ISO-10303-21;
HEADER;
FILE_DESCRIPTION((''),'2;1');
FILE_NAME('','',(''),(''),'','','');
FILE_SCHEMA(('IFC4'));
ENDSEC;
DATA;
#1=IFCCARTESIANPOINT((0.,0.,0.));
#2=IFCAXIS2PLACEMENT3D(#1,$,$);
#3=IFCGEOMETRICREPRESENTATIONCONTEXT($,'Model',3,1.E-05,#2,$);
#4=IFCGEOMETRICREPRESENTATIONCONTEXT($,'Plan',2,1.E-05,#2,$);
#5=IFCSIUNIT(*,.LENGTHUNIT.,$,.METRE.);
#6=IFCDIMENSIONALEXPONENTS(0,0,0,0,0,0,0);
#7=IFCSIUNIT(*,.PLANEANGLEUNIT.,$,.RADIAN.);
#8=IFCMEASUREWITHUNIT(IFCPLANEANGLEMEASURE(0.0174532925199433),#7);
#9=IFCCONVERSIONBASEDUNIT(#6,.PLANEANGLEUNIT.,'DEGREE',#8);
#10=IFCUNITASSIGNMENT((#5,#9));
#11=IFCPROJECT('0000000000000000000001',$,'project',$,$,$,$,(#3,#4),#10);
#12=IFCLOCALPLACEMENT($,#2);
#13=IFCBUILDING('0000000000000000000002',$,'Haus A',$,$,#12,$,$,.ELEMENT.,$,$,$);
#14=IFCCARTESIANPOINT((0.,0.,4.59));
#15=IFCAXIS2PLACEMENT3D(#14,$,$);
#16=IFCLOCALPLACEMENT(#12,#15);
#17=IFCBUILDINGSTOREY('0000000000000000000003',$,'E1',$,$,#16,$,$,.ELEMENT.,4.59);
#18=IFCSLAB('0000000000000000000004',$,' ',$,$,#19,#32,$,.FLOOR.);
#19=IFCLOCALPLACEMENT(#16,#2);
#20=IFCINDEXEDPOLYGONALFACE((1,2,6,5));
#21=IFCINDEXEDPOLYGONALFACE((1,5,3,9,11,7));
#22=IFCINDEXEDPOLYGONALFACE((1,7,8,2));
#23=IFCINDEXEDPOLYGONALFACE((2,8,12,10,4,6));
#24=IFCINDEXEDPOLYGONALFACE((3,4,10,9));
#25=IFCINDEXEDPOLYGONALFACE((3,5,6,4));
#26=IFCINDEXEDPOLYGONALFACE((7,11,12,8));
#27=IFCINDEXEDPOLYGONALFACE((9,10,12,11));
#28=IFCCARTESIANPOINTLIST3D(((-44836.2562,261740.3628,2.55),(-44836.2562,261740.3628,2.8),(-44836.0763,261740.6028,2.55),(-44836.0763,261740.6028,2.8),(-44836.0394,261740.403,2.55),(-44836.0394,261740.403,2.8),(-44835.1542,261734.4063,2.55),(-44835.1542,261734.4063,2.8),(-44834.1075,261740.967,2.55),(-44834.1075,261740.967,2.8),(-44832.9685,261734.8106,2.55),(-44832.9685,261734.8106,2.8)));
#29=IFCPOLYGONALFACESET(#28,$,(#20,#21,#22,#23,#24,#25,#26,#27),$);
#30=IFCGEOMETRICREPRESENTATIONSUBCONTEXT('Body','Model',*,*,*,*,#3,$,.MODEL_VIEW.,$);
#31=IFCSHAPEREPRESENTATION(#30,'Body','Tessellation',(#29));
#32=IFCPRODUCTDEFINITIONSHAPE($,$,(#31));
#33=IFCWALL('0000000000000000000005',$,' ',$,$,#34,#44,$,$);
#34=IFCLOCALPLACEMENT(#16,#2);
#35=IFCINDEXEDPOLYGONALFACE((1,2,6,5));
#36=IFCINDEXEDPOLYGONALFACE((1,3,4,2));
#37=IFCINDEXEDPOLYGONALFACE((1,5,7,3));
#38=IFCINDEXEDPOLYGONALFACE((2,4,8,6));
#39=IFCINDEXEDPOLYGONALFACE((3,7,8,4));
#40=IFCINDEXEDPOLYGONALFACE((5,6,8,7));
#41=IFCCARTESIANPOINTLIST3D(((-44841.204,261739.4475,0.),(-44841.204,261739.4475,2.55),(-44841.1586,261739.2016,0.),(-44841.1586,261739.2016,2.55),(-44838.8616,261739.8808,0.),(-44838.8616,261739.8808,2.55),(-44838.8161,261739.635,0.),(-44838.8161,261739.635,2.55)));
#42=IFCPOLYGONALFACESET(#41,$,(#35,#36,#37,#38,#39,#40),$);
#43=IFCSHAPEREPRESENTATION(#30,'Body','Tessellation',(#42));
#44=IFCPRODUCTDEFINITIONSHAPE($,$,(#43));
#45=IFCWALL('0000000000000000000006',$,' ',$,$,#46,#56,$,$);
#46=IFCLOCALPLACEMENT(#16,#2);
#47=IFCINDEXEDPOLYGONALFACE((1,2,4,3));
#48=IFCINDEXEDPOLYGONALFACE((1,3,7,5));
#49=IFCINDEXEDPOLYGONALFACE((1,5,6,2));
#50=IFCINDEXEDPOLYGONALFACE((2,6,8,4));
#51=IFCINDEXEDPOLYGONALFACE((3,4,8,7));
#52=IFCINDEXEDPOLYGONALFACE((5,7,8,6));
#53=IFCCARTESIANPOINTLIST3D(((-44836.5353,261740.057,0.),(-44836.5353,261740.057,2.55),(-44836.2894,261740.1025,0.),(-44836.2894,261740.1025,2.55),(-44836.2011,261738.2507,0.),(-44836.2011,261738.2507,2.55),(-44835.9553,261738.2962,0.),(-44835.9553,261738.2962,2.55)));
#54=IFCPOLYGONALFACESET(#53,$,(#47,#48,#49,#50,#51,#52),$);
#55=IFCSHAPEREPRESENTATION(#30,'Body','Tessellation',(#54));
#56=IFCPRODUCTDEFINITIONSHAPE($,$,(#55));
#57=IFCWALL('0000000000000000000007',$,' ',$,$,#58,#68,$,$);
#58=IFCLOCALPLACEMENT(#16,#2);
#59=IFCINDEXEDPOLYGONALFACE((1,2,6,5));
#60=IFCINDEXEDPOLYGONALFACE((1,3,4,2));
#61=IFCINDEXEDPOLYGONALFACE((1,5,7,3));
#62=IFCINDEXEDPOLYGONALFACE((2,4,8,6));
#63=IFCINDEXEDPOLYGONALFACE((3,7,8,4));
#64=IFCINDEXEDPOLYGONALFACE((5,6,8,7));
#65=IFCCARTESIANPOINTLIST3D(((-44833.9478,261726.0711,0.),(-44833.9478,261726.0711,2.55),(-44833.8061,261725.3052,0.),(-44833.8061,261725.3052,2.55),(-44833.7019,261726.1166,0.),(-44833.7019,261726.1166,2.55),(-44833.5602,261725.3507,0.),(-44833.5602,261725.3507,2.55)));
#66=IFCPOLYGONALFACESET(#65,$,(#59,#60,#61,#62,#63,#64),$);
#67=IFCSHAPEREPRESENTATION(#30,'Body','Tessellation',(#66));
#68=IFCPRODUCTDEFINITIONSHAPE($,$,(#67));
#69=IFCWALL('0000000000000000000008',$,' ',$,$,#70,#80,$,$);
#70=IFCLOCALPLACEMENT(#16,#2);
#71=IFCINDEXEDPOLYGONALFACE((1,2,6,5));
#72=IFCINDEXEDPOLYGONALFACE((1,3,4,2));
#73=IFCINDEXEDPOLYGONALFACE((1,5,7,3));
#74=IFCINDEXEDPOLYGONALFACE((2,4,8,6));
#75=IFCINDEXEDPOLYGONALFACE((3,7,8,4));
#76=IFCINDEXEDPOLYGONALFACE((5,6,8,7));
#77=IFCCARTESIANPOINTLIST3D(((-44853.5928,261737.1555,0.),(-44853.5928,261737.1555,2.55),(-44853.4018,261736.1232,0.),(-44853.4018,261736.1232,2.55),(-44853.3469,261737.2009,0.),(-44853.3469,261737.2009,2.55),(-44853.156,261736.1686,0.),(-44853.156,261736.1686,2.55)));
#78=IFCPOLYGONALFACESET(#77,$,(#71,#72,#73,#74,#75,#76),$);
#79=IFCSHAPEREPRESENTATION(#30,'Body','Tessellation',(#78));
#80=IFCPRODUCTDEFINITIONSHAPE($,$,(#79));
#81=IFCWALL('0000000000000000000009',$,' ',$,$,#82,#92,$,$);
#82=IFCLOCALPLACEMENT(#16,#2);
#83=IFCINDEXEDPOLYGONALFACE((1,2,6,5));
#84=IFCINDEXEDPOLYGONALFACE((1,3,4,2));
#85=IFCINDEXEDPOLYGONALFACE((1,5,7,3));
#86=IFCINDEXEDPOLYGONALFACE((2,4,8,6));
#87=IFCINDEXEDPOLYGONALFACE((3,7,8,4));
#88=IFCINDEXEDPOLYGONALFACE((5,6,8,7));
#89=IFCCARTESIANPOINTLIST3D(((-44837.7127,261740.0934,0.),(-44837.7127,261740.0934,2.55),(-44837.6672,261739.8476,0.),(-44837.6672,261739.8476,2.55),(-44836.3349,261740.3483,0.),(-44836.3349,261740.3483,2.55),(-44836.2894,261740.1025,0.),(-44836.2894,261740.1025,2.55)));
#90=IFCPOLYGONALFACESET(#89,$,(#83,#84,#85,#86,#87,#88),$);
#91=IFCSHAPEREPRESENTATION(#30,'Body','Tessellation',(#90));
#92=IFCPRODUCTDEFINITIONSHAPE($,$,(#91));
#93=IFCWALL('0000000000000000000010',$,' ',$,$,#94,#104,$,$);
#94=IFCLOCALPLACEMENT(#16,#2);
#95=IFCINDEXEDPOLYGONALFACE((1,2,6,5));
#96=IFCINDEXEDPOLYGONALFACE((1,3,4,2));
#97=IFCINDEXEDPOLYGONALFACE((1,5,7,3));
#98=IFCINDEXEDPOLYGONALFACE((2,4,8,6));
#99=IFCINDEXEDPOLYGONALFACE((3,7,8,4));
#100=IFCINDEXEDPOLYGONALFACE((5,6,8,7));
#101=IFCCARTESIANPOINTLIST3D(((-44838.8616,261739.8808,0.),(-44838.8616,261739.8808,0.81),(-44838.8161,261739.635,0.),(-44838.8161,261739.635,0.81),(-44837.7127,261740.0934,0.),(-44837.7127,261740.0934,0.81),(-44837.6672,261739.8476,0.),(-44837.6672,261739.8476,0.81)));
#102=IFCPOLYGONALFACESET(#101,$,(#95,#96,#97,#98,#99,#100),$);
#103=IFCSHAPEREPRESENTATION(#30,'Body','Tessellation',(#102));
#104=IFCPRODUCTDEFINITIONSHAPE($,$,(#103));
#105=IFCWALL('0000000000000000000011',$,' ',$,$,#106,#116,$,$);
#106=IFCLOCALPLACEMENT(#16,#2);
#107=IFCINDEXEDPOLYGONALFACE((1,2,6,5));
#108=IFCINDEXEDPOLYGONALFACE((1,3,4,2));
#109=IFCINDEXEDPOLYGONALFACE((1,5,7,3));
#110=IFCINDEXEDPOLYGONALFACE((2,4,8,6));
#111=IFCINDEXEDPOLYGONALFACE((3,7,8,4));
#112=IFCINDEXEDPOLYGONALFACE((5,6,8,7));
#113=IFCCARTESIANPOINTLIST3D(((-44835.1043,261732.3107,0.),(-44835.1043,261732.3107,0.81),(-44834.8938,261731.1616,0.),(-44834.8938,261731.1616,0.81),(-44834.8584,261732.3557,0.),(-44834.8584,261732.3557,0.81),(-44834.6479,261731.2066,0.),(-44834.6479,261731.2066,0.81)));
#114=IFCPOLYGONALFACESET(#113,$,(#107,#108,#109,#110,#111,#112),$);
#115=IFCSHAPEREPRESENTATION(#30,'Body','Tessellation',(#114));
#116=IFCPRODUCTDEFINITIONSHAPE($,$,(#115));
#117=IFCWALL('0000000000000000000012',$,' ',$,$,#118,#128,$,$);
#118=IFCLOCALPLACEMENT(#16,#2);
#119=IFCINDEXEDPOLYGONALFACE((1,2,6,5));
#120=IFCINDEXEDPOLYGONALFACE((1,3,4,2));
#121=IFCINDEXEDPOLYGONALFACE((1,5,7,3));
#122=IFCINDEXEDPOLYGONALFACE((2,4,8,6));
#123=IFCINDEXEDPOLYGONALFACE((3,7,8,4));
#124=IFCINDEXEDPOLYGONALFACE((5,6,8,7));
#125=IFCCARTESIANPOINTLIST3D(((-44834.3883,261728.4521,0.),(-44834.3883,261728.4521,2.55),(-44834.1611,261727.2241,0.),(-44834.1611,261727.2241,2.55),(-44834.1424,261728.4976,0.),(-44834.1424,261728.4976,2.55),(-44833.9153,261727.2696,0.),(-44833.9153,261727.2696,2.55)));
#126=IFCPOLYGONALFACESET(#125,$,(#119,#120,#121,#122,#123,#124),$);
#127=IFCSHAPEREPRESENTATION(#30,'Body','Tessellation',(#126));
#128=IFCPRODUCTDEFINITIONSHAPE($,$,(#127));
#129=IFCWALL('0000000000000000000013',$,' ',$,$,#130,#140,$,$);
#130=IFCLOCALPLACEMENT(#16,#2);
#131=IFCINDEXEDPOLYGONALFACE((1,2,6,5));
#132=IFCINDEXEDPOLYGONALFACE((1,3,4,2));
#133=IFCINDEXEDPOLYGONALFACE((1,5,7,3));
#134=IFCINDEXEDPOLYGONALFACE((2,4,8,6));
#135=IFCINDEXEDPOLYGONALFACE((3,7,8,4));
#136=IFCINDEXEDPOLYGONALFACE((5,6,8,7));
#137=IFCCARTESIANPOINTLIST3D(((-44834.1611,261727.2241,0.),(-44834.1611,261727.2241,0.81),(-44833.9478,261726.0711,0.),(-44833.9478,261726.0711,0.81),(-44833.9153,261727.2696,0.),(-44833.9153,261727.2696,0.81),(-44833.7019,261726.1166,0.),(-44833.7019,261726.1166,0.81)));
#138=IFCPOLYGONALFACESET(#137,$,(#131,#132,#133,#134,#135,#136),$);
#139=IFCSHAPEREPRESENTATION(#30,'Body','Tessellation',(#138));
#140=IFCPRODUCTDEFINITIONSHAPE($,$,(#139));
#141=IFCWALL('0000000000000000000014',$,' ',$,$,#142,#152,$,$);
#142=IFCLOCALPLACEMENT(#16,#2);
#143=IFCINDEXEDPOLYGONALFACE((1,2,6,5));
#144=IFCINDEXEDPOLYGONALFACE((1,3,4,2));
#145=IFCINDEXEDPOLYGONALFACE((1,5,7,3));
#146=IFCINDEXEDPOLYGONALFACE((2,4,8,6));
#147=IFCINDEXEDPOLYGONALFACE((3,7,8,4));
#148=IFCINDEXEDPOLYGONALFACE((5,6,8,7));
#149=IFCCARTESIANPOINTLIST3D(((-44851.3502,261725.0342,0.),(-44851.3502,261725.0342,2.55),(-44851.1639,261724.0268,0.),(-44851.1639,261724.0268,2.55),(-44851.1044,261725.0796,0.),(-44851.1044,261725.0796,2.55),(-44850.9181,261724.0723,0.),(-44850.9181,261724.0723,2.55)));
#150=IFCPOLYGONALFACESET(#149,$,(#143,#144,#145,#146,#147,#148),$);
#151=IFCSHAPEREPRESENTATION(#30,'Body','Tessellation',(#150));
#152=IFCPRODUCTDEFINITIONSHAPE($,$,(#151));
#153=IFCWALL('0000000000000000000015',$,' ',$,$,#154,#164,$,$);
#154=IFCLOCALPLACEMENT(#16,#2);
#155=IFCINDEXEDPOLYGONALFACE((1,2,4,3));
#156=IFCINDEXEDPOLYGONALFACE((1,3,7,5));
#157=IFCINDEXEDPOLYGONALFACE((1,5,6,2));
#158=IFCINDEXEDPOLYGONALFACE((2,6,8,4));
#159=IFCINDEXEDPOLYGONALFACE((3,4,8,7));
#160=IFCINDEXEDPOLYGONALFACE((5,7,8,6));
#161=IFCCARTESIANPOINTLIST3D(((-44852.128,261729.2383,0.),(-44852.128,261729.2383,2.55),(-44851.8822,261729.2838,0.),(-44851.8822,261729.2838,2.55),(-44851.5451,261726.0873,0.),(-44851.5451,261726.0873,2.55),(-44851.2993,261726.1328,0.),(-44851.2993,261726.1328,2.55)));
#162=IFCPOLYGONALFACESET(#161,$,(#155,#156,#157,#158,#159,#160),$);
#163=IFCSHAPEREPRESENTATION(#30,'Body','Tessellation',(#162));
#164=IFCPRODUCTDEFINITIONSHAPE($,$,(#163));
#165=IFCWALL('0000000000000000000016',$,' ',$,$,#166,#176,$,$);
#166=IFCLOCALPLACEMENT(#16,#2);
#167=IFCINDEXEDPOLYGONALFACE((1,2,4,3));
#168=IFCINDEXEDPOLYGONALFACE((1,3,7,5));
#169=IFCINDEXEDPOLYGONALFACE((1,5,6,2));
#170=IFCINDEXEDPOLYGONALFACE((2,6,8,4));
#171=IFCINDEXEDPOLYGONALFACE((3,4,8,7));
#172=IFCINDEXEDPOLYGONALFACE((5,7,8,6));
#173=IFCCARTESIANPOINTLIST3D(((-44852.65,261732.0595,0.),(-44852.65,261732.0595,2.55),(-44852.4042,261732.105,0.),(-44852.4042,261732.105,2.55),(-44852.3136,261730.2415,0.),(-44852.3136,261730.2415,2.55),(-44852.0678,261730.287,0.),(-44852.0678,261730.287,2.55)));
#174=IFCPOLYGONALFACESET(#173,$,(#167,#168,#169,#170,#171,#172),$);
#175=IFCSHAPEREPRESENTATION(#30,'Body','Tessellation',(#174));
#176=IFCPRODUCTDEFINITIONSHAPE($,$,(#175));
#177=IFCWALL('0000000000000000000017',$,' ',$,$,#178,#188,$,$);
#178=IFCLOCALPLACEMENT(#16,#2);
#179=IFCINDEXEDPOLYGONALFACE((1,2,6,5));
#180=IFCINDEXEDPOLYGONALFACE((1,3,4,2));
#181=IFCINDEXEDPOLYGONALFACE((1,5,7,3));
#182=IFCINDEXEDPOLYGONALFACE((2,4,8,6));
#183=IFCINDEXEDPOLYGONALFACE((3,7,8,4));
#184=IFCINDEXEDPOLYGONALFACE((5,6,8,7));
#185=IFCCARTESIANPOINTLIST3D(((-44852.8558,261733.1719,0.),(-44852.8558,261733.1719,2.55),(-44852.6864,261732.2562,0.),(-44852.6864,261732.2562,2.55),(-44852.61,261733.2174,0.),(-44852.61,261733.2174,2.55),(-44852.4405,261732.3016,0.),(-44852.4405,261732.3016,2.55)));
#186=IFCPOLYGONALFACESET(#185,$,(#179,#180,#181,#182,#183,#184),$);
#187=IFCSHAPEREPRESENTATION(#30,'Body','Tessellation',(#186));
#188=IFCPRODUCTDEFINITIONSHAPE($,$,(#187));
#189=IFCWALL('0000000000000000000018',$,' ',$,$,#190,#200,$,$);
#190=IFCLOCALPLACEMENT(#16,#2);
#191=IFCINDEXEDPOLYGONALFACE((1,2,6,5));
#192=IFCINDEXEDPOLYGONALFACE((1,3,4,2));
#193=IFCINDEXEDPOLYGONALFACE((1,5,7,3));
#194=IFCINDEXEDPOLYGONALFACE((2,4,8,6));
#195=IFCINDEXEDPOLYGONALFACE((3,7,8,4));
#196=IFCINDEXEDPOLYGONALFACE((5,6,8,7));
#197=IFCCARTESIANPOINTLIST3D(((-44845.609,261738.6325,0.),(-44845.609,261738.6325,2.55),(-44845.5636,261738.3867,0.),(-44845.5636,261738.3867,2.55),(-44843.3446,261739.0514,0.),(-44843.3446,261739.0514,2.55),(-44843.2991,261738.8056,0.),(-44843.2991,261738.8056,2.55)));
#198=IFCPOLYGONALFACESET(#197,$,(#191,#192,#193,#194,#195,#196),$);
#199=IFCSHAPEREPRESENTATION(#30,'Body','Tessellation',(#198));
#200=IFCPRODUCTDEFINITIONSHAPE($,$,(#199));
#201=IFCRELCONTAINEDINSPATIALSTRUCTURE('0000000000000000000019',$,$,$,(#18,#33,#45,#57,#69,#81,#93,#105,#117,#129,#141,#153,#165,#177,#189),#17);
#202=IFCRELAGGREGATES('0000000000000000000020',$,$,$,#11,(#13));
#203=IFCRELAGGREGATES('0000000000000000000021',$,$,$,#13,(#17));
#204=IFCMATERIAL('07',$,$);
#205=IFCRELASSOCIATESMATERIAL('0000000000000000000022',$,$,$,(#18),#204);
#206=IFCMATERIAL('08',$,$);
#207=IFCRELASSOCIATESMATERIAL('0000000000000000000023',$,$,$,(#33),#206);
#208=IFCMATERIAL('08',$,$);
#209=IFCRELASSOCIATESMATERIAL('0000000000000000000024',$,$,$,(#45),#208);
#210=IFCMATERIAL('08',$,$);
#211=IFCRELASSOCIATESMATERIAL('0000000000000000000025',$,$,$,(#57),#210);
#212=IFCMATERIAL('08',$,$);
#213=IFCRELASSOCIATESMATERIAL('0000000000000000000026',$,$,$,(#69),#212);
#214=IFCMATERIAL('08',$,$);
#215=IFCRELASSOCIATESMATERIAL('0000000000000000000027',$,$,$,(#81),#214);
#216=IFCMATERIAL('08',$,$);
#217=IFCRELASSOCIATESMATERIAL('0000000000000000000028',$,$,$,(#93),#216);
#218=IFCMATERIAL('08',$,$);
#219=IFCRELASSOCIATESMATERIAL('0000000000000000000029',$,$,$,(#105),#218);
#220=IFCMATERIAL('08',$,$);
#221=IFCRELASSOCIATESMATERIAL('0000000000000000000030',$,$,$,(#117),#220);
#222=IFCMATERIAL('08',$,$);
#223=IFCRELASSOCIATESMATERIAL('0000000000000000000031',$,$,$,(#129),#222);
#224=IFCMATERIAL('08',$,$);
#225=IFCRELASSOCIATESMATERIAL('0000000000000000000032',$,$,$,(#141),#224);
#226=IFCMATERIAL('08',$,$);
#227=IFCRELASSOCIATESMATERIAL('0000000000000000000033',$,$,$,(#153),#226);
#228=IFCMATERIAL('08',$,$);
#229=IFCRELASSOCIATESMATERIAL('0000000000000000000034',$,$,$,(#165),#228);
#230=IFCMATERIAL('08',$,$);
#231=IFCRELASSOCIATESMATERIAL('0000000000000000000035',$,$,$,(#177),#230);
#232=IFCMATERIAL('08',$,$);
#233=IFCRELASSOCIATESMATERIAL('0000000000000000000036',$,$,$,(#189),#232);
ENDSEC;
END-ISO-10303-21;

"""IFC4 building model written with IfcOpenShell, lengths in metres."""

from ifc_helpers import new_model, entity, si_unit, converted_unit, frame, frame_2d, origin, origin_with_axes, place, context, subcontext, project, spatial, polyline, rectangle, outline, extrude, material, element, save


model = new_model("IFC4")

# Units and contexts
model_context = context("Model", 3, precision=1e-05, world=origin())
plan_context = context("Plan", 2, precision=1e-05, world=origin())
body_context = subcontext(model_context, "Body", "Model", "MODEL_VIEW")
ifc_project = project(units=[si_unit("LENGTHUNIT", "METRE"), converted_unit("PLANEANGLEUNIT", "DEGREE", entity("IfcPlaneAngleMeasure", 0.0174532925199433), si_unit("PLANEANGLEUNIT", "RADIAN"), dimensions=[0, 0, 0, 0, 0, 0, 0])], contexts=[model_context, plan_context])

# Building, storey
building_placement = place(None, origin())
building = spatial("IfcBuilding", under=ifc_project, at=building_placement, Name="Haus A", CompositionType="ELEMENT")
storey_placement = place(building_placement, frame((0.0, 0.0, 4.59)))
storey = spatial("IfcBuildingStorey", under=building, at=storey_placement, Name="E1", CompositionType="ELEMENT", Elevation=4.59)

# Slab
ifc_material_1 = material(Name="07")
slab_placement = place(storey_placement, frame((-44836.2562, 261734.4063, 2.55)))
element("IfcSlab", 1, at=slab_placement, inside=storey, material=ifc_material_1, Name=" ", PredefinedType="FLOOR", context=body_context, shape_type="SweptSolid", body=[
    extrude(outline(polyline([(1.102, 0.0), (3.2878, 0.4044), (2.1488, 6.5608), (0.1799, 6.1965), (0.2169, 5.9967), (0.0, 5.9566), (1.102, 0.0)])), origin_with_axes(), (0.0, 0.0, 1.0), 0.25),
])

# Walls
ifc_material_2 = material(Name="08")
wall_1_placement = place(storey_placement, frame((-44838.8616, 261739.8808, 0.0), z_axis=(0.0, 0.0, 1.0), x_axis=(-0.983313, -0.18192, 0.0)))
element("IfcWall", 2, at=wall_1_placement, inside=storey, material=ifc_material_2, Name=" ", context=body_context, shape_type="SweptSolid", body=[
    extrude(rectangle(XDim=2.3822, YDim=0.25, at=frame_2d((1.1911, 0.125), x_axis=(1.0, 0.0))), origin_with_axes(), (0.0, 0.0, 1.0), 2.55),
])
ifc_material_3 = material(Name="08")
wall_2_placement = place(storey_placement, frame((-44835.9553, 261738.2962, 0.0), z_axis=(0.0, 0.0, 1.0), x_axis=(-0.18192, 0.983313, 0.0)))
element("IfcWall", 3, at=wall_2_placement, inside=storey, material=ifc_material_3, Name=" ", context=body_context, shape_type="SweptSolid", body=[
    extrude(rectangle(XDim=1.837, YDim=0.25, at=frame_2d((0.9185, 0.125), x_axis=(1.0, 0.0))), origin_with_axes(), (0.0, 0.0, 1.0), 2.55),
])
ifc_material_4 = material(Name="08")
wall_3_placement = place(storey_placement, frame((-44833.5602, 261725.3507, 0.0), z_axis=(0.0, 0.0, 1.0), x_axis=(-0.18192, 0.983313, 0.0)))
element("IfcWall", 4, at=wall_3_placement, inside=storey, material=ifc_material_4, Name=" ", context=body_context, shape_type="SweptSolid", body=[
    extrude(rectangle(XDim=0.7789, YDim=0.25, at=frame_2d((0.3895, 0.125), x_axis=(1.0, 0.0))), origin_with_axes(), (0.0, 0.0, 1.0), 2.55),
])
ifc_material_5 = material(Name="08")
wall_4_placement = place(storey_placement, frame((-44853.5928, 261737.1555, 0.0), z_axis=(0.0, 0.0, 1.0), x_axis=(0.18192, -0.983313, 0.0)))
element("IfcWall", 5, at=wall_4_placement, inside=storey, material=ifc_material_5, Name=" ", context=body_context, shape_type="SweptSolid", body=[
    extrude(rectangle(XDim=1.0498, YDim=0.25, at=frame_2d((0.5249, 0.125), x_axis=(1.0, 0.0))), origin_with_axes(), (0.0, 0.0, 1.0), 2.55),
])
ifc_material_6 = material(Name="08")
wall_5_placement = place(storey_placement, frame((-44836.3349, 261740.3483, 0.0), z_axis=(0.0, 0.0, 1.0), x_axis=(-0.983313, -0.18192, 0.0)))
element("IfcWall", 6, at=wall_5_placement, inside=storey, material=ifc_material_6, Name=" ", context=body_context, shape_type="SweptSolid", body=[
    extrude(rectangle(XDim=1.4012, YDim=0.25, at=frame_2d((0.7006, 0.125), x_axis=(1.0, 0.0))), origin_with_axes(), (0.0, 0.0, 1.0), 2.55),
])
ifc_material_7 = material(Name="08")
wall_6_placement = place(storey_placement, frame((-44837.7127, 261740.0934, 0.0), z_axis=(0.0, 0.0, 1.0), x_axis=(-0.983313, -0.18192, 0.0)))
element("IfcWall", 7, at=wall_6_placement, inside=storey, material=ifc_material_7, Name=" ", context=body_context, shape_type="SweptSolid", body=[
    extrude(rectangle(XDim=1.1684, YDim=0.25, at=frame_2d((0.5842, 0.125), x_axis=(1.0, 0.0))), origin_with_axes(), (0.0, 0.0, 1.0), 0.81),
])
ifc_material_8 = material(Name="08")
wall_7_placement = place(storey_placement, frame((-44834.6479, 261731.2066, 0.0), z_axis=(0.0, 0.0, 1.0), x_axis=(-0.180125, 0.983644, 0.0)))
element("IfcWall", 8, at=wall_7_placement, inside=storey, material=ifc_material_8, Name=" ", context=body_context, shape_type="SweptSolid", body=[
    extrude(rectangle(XDim=1.1682, YDim=0.25, at=frame_2d((0.5841, 0.125), x_axis=(1.0, 0.0))), origin_with_axes(), (0.0, 0.0, 1.0), 0.81),
])
ifc_material_9 = material(Name="08")
wall_8_placement = place(storey_placement, frame((-44833.9153, 261727.2696, 0.0), z_axis=(0.0, 0.0, 1.0), x_axis=(-0.18192, 0.983313, 0.0)))
element("IfcWall", 9, at=wall_8_placement, inside=storey, material=ifc_material_9, Name=" ", context=body_context, shape_type="SweptSolid", body=[
    extrude(rectangle(XDim=1.2488, YDim=0.25, at=frame_2d((0.6244, 0.125), x_axis=(1.0, 0.0))), origin_with_axes(), (0.0, 0.0, 1.0), 2.55),
])
ifc_material_10 = material(Name="08")
wall_9_placement = place(storey_placement, frame((-44833.7019, 261726.1166, 0.0), z_axis=(0.0, 0.0, 1.0), x_axis=(-0.18192, 0.983313, 0.0)))
element("IfcWall", 10, at=wall_9_placement, inside=storey, material=ifc_material_10, Name=" ", context=body_context, shape_type="SweptSolid", body=[
    extrude(rectangle(XDim=1.1726, YDim=0.25, at=frame_2d((0.5863, 0.125), x_axis=(1.0, 0.0))), origin_with_axes(), (0.0, 0.0, 1.0), 0.81),
])
ifc_material_11 = material(Name="08")
wall_10_placement = place(storey_placement, frame((-44851.3502, 261725.0342, 0.0), z_axis=(0.0, 0.0, 1.0), x_axis=(0.18192, -0.983313, 0.0)))
element("IfcWall", 11, at=wall_10_placement, inside=storey, material=ifc_material_11, Name=" ", context=body_context, shape_type="SweptSolid", body=[
    extrude(rectangle(XDim=1.0244, YDim=0.25, at=frame_2d((0.5122, 0.125), x_axis=(1.0, 0.0))), origin_with_axes(), (0.0, 0.0, 1.0), 2.55),
])
ifc_material_12 = material(Name="08")
wall_11_placement = place(storey_placement, frame((-44852.128, 261729.2383, 0.0), z_axis=(0.0, 0.0, 1.0), x_axis=(0.18192, -0.983313, 0.0)))
element("IfcWall", 12, at=wall_11_placement, inside=storey, material=ifc_material_12, Name=" ", context=body_context, shape_type="SweptSolid", body=[
    extrude(rectangle(XDim=3.2045, YDim=0.25, at=frame_2d((1.6023, 0.125), x_axis=(1.0, 0.0))), origin_with_axes(), (0.0, 0.0, 1.0), 2.55),
])
ifc_material_13 = material(Name="08")
wall_12_placement = place(storey_placement, frame((-44852.65, 261732.0595, 0.0), z_axis=(0.0, 0.0, 1.0), x_axis=(0.18192, -0.983313, 0.0)))
element("IfcWall", 13, at=wall_12_placement, inside=storey, material=ifc_material_13, Name=" ", context=body_context, shape_type="SweptSolid", body=[
    extrude(rectangle(XDim=1.8489, YDim=0.25, at=frame_2d((0.9244, 0.125), x_axis=(1.0, 0.0))), origin_with_axes(), (0.0, 0.0, 1.0), 2.55),
])
ifc_material_14 = material(Name="08")
wall_13_placement = place(storey_placement, frame((-44852.8558, 261733.1719, 0.0), z_axis=(0.0, 0.0, 1.0), x_axis=(0.18192, -0.983313, 0.0)))
element("IfcWall", 14, at=wall_13_placement, inside=storey, material=ifc_material_14, Name=" ", context=body_context, shape_type="SweptSolid", body=[
    extrude(rectangle(XDim=0.9313, YDim=0.25, at=frame_2d((0.4656, 0.125), x_axis=(1.0, 0.0))), origin_with_axes(), (0.0, 0.0, 1.0), 2.55),
])
ifc_material_15 = material(Name="08")
wall_14_placement = place(storey_placement, frame((-44843.3446, 261739.0514, 0.0), z_axis=(0.0, 0.0, 1.0), x_axis=(-0.983313, -0.18192, 0.0)))
element("IfcWall", 15, at=wall_14_placement, inside=storey, material=ifc_material_15, Name=" ", context=body_context, shape_type="SweptSolid", body=[
    extrude(rectangle(XDim=2.3028, YDim=0.25, at=frame_2d((1.1514, 0.125), x_axis=(1.0, 0.0))), origin_with_axes(), (0.0, 0.0, 1.0), 2.55),
])

save(model, "model.ifc")
